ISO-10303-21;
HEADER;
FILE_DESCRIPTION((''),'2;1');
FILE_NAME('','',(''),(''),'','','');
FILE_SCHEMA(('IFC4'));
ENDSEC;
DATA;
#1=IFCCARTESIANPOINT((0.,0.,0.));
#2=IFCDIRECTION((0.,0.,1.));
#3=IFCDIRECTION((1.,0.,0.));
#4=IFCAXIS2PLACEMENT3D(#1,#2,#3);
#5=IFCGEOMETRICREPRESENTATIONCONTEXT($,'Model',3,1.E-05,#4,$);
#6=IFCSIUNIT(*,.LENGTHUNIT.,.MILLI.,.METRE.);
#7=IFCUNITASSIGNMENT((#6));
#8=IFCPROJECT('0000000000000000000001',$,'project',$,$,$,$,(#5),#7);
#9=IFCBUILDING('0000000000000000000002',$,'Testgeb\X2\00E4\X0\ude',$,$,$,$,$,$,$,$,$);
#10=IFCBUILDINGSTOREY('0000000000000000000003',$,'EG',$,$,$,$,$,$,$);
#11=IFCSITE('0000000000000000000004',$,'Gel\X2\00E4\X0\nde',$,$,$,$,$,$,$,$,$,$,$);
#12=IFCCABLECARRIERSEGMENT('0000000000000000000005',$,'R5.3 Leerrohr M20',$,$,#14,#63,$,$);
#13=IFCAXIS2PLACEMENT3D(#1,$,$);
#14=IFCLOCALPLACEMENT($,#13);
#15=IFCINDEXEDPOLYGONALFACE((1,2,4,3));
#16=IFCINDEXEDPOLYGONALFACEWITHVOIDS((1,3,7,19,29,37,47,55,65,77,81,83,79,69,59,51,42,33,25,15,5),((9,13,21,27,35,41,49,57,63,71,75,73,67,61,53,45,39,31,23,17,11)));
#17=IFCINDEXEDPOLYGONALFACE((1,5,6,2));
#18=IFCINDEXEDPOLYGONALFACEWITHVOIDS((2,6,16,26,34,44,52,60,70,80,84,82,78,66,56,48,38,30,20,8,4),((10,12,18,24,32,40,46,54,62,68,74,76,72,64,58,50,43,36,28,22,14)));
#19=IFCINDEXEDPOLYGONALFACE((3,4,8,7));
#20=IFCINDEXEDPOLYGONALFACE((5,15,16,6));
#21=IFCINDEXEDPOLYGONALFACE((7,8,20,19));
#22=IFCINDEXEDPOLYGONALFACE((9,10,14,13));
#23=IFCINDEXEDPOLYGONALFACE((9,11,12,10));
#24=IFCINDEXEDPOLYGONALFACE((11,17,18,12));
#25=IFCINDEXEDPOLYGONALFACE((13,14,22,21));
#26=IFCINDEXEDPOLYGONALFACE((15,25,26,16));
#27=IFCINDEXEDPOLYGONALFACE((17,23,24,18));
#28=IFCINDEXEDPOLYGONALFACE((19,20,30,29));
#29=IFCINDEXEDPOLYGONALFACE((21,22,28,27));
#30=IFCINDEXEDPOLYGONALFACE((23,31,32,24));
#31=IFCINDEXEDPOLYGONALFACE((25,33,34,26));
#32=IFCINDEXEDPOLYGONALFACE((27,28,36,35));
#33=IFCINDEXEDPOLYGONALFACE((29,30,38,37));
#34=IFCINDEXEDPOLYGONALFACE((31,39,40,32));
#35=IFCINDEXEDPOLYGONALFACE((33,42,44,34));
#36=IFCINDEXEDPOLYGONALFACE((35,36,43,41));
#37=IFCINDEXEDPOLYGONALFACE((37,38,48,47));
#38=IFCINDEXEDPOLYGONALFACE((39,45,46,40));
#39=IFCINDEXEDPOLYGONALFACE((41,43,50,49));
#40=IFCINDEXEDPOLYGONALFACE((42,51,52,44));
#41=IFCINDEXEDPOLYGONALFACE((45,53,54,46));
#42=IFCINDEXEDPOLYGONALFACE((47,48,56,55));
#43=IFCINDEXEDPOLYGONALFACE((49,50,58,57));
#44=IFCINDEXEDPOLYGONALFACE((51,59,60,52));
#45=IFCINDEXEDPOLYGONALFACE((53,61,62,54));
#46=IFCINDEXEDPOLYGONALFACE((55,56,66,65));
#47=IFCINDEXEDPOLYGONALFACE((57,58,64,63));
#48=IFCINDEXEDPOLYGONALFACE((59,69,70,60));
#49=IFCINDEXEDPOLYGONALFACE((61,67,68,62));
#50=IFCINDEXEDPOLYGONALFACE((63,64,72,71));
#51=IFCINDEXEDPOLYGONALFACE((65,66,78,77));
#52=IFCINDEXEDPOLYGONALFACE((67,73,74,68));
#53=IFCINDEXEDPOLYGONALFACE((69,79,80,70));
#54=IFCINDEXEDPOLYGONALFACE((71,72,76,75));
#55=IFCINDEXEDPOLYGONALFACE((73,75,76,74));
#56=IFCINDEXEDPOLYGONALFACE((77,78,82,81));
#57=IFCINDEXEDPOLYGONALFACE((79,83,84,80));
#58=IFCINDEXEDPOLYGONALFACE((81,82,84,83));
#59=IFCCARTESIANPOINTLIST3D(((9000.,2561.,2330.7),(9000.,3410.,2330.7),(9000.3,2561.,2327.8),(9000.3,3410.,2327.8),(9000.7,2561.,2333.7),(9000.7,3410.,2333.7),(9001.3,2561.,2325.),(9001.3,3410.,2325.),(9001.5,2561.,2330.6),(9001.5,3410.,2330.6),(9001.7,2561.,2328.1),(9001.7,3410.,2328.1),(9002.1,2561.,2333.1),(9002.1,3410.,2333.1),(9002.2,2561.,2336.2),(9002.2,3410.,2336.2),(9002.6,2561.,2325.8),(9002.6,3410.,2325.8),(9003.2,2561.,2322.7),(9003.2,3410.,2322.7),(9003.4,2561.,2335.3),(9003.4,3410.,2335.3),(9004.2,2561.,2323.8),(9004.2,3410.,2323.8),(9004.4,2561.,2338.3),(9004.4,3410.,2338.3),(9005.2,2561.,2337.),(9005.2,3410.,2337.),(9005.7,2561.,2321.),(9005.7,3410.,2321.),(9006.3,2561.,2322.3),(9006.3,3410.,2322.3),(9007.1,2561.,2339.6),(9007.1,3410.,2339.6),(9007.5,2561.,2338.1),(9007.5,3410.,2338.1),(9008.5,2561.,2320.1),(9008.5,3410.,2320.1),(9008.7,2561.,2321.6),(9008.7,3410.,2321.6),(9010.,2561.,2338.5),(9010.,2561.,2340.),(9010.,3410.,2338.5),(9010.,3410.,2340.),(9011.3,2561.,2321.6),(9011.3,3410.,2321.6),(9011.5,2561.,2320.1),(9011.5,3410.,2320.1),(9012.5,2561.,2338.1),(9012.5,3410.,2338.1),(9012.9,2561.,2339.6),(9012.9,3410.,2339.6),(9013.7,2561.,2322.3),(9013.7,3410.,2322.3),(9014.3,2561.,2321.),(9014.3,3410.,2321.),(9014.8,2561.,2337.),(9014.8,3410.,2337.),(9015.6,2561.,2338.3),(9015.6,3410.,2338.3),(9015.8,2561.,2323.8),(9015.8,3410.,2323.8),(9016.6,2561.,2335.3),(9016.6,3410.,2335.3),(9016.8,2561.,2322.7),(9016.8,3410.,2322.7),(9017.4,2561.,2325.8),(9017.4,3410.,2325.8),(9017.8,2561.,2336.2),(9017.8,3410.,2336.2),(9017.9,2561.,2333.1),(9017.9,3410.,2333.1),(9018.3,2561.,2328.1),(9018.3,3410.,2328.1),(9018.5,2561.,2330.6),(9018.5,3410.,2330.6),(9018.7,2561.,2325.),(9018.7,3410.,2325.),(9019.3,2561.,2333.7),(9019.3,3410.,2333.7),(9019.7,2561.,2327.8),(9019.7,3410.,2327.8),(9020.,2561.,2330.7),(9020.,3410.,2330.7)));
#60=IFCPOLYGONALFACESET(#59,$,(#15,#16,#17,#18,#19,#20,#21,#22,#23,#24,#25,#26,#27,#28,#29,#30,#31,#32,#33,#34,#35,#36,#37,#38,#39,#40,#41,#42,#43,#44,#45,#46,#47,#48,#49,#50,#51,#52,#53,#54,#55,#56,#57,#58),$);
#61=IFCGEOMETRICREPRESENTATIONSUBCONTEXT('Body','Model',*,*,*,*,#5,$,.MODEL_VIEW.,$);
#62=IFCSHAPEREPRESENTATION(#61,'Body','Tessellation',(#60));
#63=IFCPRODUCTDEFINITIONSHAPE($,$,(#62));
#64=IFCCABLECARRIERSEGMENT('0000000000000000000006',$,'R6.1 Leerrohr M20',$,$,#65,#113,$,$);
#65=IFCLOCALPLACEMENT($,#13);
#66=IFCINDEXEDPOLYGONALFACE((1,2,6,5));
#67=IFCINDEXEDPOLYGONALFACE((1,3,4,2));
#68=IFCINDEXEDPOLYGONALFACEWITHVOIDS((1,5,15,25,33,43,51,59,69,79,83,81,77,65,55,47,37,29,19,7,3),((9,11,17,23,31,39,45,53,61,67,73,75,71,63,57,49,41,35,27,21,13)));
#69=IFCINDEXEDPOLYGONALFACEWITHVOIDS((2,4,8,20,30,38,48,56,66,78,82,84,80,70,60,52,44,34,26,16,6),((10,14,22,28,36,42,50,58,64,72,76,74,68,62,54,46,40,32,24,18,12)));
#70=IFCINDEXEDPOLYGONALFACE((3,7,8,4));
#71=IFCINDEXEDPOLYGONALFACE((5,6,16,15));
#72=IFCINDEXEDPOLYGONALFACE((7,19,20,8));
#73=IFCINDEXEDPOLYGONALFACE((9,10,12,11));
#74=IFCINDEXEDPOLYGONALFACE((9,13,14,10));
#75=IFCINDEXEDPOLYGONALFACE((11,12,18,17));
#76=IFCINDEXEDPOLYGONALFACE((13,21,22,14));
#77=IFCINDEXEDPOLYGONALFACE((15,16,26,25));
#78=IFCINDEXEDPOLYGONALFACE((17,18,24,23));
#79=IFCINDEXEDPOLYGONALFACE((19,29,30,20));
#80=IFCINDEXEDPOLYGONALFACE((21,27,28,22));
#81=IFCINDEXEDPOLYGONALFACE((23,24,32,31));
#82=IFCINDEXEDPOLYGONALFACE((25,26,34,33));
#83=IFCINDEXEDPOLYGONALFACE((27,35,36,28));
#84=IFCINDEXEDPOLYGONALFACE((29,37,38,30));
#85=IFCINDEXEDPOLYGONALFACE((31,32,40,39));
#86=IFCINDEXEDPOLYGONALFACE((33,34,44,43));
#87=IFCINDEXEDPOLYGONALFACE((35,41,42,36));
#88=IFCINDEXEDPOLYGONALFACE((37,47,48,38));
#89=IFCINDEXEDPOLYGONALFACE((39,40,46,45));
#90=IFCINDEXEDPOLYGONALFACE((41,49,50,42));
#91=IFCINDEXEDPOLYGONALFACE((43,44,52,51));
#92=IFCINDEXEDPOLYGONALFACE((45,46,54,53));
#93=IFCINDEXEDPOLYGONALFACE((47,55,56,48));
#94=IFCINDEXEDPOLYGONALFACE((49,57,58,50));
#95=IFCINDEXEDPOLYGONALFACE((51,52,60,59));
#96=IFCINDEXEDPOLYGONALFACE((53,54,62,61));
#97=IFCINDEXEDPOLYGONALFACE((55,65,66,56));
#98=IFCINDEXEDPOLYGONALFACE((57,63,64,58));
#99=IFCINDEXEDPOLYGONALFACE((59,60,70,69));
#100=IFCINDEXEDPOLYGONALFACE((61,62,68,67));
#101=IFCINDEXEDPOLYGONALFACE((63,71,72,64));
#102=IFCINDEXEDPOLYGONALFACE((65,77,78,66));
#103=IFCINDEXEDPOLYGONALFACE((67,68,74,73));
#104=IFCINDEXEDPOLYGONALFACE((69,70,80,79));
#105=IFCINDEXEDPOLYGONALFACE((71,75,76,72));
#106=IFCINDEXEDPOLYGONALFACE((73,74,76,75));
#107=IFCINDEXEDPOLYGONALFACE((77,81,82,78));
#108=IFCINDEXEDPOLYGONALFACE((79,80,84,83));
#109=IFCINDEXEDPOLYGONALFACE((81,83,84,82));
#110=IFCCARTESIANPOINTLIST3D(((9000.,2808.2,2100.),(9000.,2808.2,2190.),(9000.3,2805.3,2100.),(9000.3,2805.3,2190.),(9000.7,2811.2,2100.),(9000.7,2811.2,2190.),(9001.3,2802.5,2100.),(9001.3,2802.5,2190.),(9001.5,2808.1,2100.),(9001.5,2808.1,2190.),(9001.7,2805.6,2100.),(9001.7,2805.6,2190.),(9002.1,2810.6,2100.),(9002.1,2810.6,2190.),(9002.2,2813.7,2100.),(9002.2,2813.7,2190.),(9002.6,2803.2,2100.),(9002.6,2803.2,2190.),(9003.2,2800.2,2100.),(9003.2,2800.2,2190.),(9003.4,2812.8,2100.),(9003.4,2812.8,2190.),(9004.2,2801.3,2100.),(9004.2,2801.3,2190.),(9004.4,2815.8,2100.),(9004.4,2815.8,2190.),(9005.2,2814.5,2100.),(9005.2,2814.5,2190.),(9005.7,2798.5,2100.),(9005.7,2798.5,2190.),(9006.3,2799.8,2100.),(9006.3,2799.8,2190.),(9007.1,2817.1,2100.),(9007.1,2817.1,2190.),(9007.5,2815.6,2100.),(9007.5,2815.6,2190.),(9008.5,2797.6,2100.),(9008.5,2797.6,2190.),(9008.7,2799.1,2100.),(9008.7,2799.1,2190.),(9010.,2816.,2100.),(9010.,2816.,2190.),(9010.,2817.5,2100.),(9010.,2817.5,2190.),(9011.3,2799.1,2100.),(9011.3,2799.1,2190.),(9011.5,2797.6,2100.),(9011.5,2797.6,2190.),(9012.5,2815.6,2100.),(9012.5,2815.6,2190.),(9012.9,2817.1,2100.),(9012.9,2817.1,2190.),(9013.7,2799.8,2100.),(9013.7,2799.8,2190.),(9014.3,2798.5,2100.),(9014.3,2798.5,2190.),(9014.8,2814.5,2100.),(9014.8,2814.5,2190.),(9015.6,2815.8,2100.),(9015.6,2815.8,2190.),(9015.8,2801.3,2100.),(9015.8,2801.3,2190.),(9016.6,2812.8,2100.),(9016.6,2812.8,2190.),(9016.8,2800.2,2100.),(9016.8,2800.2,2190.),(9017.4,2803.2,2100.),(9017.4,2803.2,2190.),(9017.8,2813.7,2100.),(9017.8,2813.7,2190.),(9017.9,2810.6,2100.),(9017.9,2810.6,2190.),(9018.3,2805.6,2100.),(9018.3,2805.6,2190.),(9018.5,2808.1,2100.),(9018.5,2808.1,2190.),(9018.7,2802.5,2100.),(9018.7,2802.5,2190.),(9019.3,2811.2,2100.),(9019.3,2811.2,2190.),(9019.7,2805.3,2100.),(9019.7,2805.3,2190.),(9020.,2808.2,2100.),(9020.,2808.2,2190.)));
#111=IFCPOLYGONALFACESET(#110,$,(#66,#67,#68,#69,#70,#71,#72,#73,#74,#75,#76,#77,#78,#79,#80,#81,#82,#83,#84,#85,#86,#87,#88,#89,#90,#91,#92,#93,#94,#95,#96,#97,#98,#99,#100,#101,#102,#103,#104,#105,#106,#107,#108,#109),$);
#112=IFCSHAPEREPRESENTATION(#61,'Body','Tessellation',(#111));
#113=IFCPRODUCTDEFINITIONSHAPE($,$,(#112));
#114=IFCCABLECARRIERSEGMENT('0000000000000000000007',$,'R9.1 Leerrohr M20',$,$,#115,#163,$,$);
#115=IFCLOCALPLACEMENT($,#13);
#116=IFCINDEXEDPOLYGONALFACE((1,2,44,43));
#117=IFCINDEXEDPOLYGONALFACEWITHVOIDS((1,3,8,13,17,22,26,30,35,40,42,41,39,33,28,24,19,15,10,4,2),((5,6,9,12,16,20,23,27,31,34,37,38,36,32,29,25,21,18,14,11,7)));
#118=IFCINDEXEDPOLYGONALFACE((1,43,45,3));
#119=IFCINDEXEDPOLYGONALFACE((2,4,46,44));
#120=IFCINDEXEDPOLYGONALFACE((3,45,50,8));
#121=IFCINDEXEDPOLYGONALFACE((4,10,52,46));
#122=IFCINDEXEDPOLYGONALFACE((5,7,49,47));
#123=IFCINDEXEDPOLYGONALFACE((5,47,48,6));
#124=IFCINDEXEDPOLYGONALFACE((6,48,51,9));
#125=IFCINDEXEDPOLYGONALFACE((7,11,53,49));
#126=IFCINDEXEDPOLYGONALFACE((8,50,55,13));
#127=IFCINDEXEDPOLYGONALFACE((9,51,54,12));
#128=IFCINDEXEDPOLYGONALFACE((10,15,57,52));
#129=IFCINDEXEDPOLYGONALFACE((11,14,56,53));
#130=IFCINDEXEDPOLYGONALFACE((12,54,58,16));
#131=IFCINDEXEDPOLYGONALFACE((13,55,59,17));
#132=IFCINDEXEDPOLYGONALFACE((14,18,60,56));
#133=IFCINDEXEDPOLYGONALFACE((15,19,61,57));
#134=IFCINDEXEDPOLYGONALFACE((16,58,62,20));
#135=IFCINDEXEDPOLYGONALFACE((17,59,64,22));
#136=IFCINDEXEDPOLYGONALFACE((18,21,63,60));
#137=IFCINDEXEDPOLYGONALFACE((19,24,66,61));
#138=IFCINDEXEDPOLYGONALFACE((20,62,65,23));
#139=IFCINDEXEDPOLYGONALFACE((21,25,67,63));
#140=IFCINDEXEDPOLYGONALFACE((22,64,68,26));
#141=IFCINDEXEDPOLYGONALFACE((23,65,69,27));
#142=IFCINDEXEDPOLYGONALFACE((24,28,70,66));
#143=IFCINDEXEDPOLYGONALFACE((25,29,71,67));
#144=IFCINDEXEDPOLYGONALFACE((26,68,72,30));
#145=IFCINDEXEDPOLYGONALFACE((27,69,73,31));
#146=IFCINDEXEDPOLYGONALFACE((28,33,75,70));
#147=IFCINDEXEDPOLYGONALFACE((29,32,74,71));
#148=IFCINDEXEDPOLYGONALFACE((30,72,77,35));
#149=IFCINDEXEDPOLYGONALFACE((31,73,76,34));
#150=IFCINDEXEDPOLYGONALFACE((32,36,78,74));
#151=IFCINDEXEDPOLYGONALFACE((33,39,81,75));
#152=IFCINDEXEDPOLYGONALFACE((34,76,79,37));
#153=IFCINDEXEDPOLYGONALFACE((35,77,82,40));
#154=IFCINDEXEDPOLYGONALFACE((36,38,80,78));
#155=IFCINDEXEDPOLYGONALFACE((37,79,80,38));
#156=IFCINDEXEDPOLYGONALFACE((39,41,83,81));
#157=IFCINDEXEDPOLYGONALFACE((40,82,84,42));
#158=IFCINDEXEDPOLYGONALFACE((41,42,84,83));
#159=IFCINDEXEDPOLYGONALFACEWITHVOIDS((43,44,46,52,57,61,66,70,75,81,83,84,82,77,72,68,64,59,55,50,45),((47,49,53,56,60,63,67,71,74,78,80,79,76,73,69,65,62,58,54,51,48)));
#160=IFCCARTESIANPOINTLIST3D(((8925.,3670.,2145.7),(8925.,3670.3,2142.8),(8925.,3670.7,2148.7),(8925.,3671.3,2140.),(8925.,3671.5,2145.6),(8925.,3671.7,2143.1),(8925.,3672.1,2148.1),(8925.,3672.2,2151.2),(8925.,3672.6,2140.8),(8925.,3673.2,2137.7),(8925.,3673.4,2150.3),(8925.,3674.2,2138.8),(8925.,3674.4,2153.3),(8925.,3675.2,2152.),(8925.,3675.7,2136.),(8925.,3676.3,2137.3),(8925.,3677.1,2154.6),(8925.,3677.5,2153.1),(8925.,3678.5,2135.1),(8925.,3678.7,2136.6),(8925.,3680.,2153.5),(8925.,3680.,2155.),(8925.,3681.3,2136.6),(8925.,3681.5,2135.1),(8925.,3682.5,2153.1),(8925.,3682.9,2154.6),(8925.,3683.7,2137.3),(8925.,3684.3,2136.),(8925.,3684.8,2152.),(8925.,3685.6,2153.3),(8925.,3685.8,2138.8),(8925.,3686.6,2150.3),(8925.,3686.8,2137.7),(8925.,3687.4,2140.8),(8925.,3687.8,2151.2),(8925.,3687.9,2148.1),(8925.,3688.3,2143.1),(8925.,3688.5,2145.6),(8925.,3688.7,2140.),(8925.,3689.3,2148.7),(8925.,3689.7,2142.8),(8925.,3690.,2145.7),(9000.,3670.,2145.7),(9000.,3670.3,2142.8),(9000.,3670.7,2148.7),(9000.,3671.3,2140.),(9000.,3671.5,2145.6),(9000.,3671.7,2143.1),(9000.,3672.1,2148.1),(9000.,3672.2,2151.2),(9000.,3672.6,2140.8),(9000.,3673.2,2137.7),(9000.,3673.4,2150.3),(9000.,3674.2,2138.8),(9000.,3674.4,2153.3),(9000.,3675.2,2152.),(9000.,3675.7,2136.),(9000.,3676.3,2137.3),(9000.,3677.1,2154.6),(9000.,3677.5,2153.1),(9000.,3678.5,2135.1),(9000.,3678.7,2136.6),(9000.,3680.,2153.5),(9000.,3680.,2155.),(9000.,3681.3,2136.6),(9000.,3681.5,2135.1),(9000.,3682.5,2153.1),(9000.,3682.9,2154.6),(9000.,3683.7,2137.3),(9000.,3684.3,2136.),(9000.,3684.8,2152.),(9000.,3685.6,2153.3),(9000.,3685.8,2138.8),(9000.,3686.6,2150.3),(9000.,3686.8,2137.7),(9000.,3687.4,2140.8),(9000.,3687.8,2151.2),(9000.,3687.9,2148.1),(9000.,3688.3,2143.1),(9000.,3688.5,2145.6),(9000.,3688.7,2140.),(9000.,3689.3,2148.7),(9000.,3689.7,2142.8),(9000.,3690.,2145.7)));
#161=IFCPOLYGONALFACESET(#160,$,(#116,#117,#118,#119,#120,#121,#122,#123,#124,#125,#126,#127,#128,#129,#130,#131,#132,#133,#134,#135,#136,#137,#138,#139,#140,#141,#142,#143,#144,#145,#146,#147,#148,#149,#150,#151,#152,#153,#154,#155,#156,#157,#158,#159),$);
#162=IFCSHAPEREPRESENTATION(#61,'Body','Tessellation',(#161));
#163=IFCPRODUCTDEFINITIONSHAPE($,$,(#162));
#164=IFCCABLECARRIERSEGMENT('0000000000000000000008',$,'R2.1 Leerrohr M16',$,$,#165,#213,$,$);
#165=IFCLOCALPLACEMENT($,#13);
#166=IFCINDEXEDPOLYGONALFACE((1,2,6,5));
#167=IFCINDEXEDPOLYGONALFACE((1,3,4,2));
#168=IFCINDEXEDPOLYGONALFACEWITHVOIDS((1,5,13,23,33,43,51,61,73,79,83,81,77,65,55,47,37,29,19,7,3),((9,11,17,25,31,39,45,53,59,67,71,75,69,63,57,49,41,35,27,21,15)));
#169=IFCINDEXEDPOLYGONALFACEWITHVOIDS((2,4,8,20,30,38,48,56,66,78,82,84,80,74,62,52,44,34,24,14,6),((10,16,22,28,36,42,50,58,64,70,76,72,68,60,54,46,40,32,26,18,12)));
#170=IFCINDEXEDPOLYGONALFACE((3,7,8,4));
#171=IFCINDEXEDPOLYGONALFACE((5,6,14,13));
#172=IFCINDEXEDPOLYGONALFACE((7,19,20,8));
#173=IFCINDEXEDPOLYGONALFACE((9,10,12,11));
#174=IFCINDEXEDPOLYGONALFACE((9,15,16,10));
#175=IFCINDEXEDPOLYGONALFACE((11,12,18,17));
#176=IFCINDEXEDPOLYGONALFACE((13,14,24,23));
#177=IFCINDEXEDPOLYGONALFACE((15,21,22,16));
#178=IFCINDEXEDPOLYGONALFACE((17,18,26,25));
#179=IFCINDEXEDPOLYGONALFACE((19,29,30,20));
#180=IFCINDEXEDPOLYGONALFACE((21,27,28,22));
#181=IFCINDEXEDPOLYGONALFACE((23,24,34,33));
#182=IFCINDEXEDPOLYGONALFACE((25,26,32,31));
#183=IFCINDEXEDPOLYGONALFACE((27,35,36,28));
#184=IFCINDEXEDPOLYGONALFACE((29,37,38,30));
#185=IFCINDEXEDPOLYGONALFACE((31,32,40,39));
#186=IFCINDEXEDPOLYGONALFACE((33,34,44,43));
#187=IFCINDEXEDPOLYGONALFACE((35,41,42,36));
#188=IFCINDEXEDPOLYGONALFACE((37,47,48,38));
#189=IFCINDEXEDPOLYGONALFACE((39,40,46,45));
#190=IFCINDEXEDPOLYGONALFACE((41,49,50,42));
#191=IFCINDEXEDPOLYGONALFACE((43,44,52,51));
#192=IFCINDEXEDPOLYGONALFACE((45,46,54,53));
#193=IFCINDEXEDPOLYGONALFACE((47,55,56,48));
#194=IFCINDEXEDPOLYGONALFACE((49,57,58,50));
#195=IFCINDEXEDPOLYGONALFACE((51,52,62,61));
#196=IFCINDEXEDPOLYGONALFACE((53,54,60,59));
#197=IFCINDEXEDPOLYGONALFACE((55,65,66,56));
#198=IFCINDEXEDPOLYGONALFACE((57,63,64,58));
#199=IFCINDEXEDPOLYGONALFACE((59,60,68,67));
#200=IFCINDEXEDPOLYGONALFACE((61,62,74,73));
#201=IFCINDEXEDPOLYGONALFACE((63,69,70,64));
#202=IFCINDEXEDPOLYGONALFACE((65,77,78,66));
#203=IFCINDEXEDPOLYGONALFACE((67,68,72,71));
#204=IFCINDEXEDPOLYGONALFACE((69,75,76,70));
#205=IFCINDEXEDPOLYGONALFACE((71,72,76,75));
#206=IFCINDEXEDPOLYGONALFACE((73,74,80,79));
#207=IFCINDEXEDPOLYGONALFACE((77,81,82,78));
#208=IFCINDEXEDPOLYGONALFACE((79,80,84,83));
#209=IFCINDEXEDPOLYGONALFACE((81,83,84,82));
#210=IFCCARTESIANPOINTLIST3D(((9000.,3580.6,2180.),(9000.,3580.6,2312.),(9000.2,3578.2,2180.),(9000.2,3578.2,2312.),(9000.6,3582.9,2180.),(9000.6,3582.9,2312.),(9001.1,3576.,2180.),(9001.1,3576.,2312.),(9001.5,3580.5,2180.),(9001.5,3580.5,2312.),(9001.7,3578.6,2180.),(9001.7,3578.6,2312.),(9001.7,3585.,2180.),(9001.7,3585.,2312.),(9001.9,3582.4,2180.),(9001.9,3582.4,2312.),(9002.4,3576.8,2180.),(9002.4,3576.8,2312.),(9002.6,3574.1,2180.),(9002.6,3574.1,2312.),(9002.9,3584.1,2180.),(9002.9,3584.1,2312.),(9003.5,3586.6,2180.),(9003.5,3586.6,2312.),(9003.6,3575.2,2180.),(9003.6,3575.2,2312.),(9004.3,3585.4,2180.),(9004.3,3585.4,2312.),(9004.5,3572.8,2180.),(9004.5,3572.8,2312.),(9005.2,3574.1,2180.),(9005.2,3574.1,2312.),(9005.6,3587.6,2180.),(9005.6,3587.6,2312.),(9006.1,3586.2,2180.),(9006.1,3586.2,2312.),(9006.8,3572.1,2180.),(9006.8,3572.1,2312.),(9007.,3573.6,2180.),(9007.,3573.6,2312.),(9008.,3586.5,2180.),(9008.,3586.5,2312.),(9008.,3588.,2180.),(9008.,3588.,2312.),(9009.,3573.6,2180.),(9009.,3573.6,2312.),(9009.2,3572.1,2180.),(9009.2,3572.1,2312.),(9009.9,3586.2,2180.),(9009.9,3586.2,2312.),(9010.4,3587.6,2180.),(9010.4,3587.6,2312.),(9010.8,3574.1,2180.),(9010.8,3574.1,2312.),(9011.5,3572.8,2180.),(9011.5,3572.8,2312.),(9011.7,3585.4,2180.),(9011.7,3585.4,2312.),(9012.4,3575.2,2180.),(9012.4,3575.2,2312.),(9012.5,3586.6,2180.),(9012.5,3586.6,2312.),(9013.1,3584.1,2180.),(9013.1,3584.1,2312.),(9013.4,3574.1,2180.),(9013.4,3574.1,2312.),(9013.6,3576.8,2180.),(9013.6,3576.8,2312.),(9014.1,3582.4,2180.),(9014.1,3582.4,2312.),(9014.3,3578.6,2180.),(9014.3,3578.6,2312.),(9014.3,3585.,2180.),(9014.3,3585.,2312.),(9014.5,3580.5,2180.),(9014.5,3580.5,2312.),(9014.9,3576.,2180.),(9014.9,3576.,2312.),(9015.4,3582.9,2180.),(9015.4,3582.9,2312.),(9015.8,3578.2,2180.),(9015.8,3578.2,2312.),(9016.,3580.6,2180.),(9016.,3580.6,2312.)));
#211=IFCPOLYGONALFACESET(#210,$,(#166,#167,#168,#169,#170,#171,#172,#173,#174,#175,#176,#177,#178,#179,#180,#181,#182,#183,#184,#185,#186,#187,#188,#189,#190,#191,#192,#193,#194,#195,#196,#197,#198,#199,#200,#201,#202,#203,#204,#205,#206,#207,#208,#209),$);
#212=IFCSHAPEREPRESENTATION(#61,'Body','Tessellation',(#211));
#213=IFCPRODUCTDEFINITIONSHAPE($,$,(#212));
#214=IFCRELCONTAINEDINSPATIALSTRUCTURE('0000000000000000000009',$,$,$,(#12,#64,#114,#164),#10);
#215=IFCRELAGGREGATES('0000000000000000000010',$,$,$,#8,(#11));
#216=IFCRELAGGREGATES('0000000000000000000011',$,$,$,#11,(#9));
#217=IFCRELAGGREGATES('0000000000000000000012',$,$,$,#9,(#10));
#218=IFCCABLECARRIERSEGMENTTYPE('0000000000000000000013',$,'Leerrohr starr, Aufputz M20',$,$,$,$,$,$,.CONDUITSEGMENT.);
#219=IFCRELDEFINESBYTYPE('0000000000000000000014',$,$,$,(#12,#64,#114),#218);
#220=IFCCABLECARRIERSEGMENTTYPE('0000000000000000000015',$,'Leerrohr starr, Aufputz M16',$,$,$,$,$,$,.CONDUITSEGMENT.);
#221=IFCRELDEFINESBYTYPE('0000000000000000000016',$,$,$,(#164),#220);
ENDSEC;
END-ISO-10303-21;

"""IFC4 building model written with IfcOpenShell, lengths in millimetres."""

from ifc_helpers import new_model, si_unit, frame, origin_with_axes, place, context, subcontext, project, spatial, hollow_circle, extrude, type_object, element, save


model = new_model("IFC4")

# Units and contexts
model_context = context("Model", 3, precision=1e-05, world=origin_with_axes())
body_context = subcontext(model_context, "Body", "Model", "MODEL_VIEW")
ifc_project = project(units=[si_unit("LENGTHUNIT", "METRE", prefix="MILLI")], contexts=[model_context])

# Site, building, storey
site = spatial("IfcSite", under=ifc_project, Name="Gelände")
building = spatial("IfcBuilding", under=site, Name="Testgebäude")
storey = spatial("IfcBuildingStorey", under=building, Name="EG")

# Cable carrier segments
cable_carrier_segment_type_1 = type_object("IfcCableCarrierSegmentType", Name="Leerrohr starr, Aufputz M20", PredefinedType="CONDUITSEGMENT")
cable_carrier_segment_1_placement = place(None, frame((9010.0, 3410.0, 2330.0), z_axis=(0.0, -1.0, 0.0), x_axis=(0.0, 0.0, 1.0)))
element("IfcCableCarrierSegment", 1, at=cable_carrier_segment_1_placement, inside=storey, type_object=cable_carrier_segment_type_1, Name="R5.3 Leerrohr M20", context=body_context, shape_type="SweptSolid", body=[
    extrude(hollow_circle(Radius=10.0, WallThickness=1.5), None, (0.0, 0.0, 1.0), 849.0),
])
cable_carrier_segment_2_placement = place(None, frame((9010.0, 2807.5, 2100.0), z_axis=(0.0, 0.0, 1.0), x_axis=(0.0, 1.0, 0.0)))
element("IfcCableCarrierSegment", 2, at=cable_carrier_segment_2_placement, inside=storey, type_object=cable_carrier_segment_type_1, Name="R6.1 Leerrohr M20", context=body_context, shape_type="SweptSolid", body=[
    extrude(hollow_circle(Radius=10.0, WallThickness=1.5), None, (0.0, 0.0, 1.0), 90.0),
])
cable_carrier_segment_3_placement = place(None, frame((9000.0, 3680.0, 2145.0), z_axis=(-1.0, 0.0, 0.0), x_axis=(0.0, 0.0, 1.0)))
element("IfcCableCarrierSegment", 3, at=cable_carrier_segment_3_placement, inside=storey, type_object=cable_carrier_segment_type_1, Name="R9.1 Leerrohr M20", context=body_context, shape_type="SweptSolid", body=[
    extrude(hollow_circle(Radius=10.0, WallThickness=1.5), None, (0.0, 0.0, 1.0), 75.0),
])

# Cable carrier segment
cable_carrier_segment_type_2 = type_object("IfcCableCarrierSegmentType", Name="Leerrohr starr, Aufputz M16", PredefinedType="CONDUITSEGMENT")
cable_carrier_segment_4_placement = place(None, frame((9008.0, 3580.0, 2180.0), z_axis=(0.0, 0.0, 1.0), x_axis=(0.0, 1.0, 0.0)))
element("IfcCableCarrierSegment", 4, at=cable_carrier_segment_4_placement, inside=storey, type_object=cable_carrier_segment_type_2, Name="R2.1 Leerrohr M16", context=body_context, shape_type="SweptSolid", body=[
    extrude(hollow_circle(Radius=8.0, WallThickness=1.5), None, (0.0, 0.0, 1.0), 132.0),
])

save(model, "model.ifc")
